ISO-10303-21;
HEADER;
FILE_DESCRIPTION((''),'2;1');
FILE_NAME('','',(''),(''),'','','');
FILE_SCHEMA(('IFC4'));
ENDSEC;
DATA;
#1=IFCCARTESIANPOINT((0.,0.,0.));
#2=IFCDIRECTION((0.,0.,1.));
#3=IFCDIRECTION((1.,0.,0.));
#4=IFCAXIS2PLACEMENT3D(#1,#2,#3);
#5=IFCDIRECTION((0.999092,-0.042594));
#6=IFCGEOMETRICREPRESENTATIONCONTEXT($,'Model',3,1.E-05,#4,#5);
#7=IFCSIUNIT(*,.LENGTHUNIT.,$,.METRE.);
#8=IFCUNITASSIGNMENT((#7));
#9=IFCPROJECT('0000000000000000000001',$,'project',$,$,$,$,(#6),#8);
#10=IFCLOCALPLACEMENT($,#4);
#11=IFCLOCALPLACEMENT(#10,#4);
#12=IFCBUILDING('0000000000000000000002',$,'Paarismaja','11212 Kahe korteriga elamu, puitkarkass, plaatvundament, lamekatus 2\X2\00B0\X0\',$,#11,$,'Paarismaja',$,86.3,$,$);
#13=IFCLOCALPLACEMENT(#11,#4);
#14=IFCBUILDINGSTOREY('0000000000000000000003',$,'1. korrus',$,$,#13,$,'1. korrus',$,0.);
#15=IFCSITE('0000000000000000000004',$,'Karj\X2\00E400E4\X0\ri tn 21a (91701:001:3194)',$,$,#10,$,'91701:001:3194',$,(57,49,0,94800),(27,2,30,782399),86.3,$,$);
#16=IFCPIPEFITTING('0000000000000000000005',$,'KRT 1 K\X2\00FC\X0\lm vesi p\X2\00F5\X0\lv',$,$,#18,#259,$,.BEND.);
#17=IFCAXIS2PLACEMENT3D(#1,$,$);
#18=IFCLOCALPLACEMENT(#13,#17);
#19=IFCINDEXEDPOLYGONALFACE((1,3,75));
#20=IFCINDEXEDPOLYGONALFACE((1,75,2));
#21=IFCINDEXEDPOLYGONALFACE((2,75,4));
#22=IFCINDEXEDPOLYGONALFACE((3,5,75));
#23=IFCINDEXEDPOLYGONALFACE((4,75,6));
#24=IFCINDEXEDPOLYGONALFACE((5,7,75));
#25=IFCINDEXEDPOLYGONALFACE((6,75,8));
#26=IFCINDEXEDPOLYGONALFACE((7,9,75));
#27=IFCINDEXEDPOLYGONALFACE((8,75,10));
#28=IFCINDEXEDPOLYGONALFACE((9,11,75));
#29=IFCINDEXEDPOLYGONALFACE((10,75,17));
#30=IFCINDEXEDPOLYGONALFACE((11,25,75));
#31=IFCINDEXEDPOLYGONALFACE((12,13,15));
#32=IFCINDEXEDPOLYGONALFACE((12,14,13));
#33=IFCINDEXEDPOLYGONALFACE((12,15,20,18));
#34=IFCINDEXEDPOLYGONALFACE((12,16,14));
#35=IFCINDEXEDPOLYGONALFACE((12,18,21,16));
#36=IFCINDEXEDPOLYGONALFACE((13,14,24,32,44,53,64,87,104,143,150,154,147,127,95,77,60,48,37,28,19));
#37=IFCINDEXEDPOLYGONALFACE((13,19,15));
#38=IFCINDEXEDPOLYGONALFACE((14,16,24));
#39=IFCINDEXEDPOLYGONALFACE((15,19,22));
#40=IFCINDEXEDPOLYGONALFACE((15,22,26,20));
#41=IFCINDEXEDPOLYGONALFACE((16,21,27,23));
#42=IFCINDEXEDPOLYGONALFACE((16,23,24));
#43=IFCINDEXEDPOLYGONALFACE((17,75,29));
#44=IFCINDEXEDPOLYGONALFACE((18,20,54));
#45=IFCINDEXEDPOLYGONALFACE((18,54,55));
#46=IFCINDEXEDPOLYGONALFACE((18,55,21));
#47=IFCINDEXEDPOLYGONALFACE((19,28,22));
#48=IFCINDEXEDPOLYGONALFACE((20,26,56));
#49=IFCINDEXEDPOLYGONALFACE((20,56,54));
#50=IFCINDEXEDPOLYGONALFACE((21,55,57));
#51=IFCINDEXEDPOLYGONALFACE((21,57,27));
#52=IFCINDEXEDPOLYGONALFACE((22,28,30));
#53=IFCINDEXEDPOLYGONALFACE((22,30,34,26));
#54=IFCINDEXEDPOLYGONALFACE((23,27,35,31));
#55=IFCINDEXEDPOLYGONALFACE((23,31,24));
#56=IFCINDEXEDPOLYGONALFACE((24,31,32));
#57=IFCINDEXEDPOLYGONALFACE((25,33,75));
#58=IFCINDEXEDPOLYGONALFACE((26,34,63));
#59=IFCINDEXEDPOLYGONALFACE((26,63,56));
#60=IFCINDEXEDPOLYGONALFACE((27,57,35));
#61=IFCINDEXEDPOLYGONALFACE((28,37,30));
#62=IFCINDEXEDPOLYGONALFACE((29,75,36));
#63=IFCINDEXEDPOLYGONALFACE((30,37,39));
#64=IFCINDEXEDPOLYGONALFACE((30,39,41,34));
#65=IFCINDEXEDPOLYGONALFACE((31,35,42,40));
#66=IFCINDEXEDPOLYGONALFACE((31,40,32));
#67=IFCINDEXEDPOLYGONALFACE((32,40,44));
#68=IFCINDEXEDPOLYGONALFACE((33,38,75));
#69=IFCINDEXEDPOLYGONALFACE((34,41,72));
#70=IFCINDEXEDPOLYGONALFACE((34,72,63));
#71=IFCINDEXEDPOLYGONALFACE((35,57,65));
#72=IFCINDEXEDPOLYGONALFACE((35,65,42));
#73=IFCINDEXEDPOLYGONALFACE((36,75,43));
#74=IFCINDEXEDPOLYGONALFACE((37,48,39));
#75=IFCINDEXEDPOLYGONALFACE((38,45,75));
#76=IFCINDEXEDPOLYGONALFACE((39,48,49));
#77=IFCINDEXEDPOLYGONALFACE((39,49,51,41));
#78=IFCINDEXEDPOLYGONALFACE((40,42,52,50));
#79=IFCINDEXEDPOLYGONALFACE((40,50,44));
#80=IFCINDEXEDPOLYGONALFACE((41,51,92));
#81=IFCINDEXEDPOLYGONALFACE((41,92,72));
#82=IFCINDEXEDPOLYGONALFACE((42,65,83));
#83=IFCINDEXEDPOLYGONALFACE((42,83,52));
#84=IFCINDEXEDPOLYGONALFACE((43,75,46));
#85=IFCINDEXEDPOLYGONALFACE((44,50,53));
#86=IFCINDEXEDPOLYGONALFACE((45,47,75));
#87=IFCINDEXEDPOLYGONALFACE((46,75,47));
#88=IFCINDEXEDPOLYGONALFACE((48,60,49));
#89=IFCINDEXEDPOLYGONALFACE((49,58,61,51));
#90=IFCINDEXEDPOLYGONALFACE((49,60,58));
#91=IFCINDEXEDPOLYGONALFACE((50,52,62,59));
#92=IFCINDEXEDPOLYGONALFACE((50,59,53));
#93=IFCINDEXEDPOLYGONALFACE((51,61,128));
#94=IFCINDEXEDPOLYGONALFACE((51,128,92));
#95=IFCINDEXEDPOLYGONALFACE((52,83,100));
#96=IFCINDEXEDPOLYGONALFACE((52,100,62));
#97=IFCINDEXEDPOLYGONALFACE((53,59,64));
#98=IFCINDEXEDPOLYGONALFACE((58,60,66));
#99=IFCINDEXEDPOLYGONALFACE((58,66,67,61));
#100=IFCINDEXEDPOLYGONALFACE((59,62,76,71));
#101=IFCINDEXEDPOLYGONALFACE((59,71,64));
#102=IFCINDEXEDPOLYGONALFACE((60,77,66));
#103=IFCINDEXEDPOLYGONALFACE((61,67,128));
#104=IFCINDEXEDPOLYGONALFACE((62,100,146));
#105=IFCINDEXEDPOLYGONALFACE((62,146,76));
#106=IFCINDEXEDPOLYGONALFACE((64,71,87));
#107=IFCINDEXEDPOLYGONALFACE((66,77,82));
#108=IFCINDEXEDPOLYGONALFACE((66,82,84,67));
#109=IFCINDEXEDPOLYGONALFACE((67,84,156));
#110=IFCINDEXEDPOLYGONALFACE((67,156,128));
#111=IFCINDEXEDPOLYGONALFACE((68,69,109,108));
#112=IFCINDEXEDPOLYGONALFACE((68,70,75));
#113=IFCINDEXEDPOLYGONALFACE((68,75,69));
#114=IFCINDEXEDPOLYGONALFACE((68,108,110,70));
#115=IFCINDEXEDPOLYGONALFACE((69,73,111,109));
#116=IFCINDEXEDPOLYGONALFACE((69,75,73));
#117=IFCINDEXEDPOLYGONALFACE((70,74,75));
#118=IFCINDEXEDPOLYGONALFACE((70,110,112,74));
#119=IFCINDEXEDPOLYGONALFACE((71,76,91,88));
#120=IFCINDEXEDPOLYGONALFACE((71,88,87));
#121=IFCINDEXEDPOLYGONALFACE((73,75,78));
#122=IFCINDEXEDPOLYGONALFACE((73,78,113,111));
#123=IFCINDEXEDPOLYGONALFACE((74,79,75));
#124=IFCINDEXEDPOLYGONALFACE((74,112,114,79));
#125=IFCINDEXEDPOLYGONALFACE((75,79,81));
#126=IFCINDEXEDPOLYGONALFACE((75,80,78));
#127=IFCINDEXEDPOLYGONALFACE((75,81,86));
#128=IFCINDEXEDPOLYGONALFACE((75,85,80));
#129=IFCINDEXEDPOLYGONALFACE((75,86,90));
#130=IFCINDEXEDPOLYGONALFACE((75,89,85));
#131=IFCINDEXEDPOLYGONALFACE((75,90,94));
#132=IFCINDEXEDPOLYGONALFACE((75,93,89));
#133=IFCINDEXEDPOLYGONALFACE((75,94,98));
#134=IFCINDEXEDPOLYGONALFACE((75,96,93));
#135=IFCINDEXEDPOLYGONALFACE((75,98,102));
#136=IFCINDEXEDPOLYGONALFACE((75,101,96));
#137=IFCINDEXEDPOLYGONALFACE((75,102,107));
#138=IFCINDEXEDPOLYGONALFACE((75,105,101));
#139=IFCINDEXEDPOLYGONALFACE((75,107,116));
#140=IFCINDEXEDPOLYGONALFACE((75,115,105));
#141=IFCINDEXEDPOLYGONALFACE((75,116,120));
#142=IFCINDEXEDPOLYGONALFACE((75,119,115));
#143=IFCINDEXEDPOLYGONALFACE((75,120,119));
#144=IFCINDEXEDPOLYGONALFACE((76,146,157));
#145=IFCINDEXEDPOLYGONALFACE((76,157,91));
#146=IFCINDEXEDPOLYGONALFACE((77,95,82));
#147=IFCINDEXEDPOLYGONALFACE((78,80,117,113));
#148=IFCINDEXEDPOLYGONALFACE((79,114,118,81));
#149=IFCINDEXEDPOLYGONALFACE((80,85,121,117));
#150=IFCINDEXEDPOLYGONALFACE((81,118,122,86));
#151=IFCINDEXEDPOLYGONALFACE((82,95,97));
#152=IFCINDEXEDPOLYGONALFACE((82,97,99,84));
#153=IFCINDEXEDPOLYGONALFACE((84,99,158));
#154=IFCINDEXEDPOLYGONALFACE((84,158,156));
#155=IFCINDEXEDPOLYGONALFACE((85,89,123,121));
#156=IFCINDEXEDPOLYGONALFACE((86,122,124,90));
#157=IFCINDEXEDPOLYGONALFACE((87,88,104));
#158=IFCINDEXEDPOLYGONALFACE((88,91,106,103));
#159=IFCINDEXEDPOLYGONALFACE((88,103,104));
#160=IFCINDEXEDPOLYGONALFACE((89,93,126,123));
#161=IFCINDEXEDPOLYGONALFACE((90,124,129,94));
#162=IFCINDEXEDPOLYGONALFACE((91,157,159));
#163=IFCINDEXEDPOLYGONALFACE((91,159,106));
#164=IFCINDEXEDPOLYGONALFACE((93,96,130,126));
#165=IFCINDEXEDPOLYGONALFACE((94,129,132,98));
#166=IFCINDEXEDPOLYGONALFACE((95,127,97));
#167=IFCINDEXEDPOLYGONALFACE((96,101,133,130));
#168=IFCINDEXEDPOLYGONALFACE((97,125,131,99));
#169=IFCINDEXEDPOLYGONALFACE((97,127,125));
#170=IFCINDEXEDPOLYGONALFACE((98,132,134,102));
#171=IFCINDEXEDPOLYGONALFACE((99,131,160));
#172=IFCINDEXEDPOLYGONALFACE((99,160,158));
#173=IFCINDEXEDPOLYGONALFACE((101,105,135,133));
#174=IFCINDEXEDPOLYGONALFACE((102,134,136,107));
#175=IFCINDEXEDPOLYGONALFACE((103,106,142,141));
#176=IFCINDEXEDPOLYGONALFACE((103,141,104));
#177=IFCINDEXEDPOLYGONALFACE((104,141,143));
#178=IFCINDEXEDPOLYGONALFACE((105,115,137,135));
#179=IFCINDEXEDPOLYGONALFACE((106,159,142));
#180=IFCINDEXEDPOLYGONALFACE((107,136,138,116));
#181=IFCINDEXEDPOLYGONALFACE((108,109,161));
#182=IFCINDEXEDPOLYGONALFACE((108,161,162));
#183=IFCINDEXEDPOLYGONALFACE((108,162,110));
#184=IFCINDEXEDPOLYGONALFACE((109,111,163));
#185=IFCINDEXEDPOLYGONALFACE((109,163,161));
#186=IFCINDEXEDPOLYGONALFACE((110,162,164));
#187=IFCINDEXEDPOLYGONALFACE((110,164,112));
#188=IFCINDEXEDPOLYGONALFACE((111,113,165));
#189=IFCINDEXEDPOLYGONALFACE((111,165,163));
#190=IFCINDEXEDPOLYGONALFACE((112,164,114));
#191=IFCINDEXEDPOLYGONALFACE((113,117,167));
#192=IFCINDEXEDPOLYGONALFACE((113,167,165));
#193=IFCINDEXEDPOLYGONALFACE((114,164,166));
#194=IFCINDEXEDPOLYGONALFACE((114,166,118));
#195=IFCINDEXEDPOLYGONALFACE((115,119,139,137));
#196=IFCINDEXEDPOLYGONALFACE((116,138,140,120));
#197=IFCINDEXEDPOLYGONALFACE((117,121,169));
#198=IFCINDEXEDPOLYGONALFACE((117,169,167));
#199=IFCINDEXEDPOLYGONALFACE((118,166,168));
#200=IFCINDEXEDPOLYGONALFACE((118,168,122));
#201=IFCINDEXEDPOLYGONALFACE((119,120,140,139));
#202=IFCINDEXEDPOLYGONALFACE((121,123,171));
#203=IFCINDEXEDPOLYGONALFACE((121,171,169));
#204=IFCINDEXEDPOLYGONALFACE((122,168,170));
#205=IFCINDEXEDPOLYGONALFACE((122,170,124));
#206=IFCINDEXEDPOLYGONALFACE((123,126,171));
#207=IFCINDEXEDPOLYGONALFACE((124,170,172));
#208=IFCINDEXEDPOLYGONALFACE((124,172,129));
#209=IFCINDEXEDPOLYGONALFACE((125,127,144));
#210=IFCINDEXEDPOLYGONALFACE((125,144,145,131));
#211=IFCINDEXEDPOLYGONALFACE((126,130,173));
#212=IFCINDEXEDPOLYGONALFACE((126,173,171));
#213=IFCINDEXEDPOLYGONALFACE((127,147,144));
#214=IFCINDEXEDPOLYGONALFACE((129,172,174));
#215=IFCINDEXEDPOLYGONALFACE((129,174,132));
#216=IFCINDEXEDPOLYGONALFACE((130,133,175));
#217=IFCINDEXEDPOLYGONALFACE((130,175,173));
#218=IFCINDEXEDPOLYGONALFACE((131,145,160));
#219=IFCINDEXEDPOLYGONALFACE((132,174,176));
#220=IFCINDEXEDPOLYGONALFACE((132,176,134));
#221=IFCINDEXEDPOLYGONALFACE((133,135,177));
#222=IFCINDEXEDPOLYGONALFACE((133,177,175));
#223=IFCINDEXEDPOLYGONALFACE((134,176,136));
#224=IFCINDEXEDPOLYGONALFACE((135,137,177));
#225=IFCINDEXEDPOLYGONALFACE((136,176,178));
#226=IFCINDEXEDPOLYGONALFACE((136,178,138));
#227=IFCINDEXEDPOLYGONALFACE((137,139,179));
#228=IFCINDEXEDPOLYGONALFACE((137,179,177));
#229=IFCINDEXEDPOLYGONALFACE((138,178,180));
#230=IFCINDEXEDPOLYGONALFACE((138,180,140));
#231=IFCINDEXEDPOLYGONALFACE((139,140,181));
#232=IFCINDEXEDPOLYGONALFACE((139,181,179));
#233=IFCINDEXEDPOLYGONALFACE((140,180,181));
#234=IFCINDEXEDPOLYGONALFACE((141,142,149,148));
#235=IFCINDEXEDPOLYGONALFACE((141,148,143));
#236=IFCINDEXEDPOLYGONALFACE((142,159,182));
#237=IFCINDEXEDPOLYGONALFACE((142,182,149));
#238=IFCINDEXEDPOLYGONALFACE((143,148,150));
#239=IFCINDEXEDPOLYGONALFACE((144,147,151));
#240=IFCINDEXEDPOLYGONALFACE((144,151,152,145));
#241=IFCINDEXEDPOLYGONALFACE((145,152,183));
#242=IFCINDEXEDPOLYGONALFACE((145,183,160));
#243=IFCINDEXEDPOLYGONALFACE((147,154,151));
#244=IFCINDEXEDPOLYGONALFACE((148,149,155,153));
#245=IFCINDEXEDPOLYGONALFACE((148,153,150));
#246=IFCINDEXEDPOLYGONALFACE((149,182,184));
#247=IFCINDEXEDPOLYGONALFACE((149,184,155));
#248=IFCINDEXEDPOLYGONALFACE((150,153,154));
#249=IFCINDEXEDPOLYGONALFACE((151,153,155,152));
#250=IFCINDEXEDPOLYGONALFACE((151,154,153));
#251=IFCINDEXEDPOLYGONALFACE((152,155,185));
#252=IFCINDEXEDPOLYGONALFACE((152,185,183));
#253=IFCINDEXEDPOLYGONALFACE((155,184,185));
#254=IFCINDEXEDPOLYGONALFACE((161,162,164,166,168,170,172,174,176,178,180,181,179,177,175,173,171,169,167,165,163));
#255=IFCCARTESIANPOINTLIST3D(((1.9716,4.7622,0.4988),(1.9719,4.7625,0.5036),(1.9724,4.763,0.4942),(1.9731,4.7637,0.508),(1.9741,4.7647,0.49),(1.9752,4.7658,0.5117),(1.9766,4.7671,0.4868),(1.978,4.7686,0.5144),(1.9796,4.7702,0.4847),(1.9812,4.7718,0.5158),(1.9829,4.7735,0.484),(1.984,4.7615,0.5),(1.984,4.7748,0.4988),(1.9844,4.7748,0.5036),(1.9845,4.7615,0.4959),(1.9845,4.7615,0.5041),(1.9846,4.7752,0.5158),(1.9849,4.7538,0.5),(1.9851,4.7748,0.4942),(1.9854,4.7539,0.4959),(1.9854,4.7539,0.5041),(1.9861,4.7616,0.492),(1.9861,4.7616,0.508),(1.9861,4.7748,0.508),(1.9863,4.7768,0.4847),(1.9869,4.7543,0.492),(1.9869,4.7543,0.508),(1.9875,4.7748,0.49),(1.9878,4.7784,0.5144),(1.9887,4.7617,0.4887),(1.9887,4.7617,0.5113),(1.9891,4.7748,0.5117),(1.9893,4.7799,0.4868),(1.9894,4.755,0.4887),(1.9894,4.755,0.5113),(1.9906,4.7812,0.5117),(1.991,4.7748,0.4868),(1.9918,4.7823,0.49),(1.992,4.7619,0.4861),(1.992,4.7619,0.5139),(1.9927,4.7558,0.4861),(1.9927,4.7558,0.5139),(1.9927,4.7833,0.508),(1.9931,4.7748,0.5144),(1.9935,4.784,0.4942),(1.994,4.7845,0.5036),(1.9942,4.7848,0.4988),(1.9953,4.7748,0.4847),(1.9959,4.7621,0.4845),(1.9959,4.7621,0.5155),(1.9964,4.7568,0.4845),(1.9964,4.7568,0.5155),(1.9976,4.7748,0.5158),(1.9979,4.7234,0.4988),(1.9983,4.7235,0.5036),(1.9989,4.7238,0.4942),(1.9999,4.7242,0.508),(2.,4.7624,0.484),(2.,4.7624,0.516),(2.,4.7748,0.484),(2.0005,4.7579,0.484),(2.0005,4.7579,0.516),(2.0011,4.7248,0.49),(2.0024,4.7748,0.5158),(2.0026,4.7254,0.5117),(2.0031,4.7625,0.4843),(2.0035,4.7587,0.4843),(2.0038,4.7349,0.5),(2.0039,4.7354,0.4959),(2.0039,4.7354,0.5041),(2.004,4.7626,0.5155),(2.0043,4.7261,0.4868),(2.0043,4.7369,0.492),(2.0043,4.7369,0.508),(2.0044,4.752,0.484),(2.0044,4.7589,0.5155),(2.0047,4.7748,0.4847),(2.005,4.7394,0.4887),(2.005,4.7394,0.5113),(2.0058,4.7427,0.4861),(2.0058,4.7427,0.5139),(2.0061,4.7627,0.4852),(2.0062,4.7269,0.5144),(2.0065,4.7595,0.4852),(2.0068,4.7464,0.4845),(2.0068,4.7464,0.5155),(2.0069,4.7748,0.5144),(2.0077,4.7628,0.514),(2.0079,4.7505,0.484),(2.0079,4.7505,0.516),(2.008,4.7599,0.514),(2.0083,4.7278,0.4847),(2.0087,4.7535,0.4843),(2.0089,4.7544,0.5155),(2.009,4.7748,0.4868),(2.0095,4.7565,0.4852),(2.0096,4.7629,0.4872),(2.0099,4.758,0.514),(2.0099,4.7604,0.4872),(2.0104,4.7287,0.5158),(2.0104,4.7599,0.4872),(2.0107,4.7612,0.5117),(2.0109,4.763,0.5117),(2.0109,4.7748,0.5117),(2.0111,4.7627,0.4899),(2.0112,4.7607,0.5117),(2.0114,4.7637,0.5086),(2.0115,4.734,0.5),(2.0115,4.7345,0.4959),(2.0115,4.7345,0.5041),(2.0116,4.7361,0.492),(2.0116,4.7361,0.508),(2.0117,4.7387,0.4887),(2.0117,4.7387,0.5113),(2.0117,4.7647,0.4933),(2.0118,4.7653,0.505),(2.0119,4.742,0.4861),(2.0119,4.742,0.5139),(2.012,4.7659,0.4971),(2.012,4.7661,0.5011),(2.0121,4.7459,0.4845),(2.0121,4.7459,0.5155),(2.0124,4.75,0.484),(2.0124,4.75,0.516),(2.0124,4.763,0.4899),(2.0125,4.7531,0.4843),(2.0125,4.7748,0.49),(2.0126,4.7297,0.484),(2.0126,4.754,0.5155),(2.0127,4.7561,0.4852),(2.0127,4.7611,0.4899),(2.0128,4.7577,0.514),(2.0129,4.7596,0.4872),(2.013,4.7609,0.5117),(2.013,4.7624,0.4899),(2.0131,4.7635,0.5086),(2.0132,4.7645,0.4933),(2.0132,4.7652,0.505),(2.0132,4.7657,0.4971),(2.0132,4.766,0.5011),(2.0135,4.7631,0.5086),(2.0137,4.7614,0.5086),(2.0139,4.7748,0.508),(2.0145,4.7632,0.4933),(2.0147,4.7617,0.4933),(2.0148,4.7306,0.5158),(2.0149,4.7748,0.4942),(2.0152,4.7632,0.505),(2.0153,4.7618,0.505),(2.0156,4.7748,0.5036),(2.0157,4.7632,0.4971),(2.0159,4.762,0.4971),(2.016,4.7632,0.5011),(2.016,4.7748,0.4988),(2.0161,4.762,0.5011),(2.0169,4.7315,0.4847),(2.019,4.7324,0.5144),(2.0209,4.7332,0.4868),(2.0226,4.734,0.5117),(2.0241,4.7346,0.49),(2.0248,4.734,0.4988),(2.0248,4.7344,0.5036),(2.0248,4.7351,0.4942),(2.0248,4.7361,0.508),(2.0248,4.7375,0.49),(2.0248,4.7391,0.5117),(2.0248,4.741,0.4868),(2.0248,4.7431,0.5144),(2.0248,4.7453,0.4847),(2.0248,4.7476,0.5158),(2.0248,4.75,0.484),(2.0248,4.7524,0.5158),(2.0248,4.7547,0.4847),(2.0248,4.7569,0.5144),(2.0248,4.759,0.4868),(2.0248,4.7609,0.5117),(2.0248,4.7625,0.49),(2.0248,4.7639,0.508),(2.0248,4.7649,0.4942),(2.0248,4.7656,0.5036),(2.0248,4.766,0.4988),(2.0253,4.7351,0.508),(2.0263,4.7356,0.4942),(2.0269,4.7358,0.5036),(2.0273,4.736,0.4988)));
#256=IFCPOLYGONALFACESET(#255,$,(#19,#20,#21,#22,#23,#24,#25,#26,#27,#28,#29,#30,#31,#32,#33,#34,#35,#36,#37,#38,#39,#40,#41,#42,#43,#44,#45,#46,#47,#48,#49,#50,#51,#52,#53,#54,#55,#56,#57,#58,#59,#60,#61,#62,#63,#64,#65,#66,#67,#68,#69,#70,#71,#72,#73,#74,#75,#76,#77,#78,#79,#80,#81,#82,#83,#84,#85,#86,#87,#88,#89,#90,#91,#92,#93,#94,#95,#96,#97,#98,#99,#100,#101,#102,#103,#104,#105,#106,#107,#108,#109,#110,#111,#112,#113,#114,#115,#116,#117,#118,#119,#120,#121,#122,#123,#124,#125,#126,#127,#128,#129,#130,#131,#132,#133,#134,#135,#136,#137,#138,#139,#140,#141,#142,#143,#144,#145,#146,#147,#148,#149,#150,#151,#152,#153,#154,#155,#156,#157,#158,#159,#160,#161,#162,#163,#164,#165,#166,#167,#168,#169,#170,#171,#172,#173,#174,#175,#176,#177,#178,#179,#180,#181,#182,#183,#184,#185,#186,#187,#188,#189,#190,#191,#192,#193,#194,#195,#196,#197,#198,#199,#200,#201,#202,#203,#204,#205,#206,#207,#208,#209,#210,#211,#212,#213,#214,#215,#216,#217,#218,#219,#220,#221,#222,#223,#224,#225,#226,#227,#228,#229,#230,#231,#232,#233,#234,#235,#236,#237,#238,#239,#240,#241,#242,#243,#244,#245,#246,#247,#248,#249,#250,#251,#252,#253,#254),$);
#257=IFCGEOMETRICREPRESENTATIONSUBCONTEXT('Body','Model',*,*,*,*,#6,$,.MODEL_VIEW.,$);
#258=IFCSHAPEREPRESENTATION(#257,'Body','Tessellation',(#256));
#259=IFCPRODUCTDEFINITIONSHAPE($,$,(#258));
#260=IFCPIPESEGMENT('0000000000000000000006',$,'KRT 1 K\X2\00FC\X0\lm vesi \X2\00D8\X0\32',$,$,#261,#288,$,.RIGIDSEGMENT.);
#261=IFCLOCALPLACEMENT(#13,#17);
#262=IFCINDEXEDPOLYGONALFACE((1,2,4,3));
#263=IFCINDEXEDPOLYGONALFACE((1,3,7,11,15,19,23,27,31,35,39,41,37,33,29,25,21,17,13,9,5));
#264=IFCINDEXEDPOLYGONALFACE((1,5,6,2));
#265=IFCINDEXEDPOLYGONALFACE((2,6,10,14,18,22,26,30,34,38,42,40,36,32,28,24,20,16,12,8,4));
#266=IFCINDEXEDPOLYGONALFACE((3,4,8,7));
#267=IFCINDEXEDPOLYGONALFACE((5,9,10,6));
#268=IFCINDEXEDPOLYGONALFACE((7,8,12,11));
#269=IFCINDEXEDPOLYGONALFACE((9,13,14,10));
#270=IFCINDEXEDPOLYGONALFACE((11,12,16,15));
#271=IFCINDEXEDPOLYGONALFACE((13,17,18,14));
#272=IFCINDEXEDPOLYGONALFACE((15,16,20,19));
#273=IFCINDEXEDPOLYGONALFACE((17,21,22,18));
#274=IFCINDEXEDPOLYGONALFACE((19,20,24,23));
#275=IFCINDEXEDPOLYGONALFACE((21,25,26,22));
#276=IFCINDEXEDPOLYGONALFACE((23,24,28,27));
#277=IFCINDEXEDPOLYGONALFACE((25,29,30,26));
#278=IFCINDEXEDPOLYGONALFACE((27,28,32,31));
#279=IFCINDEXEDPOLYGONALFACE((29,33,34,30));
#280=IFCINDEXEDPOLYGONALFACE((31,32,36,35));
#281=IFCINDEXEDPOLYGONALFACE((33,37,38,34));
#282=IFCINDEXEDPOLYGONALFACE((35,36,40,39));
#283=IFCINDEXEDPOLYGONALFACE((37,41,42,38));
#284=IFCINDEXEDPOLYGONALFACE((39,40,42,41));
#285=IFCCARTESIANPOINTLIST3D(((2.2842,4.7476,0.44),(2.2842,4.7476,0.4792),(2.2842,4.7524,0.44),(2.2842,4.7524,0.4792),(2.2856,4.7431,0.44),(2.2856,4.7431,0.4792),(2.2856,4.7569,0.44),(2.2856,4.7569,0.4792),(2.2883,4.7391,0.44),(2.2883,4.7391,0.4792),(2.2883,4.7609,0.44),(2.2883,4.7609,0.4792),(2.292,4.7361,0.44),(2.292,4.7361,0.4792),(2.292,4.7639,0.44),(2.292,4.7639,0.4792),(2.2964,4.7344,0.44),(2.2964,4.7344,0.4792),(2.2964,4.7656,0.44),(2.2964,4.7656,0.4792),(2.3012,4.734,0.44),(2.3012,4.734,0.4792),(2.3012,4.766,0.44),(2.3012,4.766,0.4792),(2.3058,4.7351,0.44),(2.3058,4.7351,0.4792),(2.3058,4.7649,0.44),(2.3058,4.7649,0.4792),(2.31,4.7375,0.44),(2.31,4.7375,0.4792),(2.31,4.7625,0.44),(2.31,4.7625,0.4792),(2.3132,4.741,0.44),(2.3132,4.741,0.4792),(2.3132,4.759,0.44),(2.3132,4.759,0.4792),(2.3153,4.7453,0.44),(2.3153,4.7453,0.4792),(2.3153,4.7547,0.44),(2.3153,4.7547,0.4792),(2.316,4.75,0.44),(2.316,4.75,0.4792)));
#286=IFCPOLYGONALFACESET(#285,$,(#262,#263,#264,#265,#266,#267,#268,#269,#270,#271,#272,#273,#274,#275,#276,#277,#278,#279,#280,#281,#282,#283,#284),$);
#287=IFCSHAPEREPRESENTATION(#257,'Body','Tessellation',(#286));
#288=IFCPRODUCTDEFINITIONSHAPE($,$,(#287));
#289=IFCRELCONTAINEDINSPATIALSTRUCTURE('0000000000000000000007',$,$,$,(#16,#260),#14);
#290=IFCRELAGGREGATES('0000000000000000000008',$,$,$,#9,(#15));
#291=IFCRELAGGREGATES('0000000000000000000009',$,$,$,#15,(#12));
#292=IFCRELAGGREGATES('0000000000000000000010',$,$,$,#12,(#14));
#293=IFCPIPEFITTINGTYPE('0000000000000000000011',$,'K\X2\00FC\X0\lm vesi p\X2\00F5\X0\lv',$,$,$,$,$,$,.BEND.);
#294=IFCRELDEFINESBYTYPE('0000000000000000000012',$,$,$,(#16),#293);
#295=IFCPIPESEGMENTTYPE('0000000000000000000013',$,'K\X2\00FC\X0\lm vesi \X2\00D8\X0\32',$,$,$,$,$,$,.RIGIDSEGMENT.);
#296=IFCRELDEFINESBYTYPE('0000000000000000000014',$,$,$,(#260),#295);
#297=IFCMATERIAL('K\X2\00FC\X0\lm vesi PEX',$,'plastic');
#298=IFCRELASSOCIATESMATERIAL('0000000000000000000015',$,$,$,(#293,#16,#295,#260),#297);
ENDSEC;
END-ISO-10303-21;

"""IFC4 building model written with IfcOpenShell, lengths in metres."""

from ifc_helpers import new_model, entity, si_unit, direction, frame, origin_with_axes, place, context, subcontext, project, spatial, circle, extrude, material, type_object, element, save


model = new_model("IFC4")

# Units and contexts
model_context = context("Model", 3, precision=1e-05, world=origin_with_axes(), true_north=direction((0.999092, -0.042594)))
body_context = subcontext(model_context, "Body", "Model", "MODEL_VIEW")
ifc_project = project(units=[si_unit("LENGTHUNIT", "METRE")], contexts=[model_context])

# Site, building, storey
site_placement = place(None, origin_with_axes())
site = spatial("IfcSite", under=ifc_project, at=site_placement, Name="Karjääri tn 21a (91701:001:3194)", LongName="91701:001:3194", RefLatitude=(57, 49, 0, 94800), RefLongitude=(27, 2, 30, 782399), RefElevation=86.3)
building_placement = place(site_placement, origin_with_axes())
building = spatial("IfcBuilding", under=site, at=building_placement, Name="Paarismaja", Description="11212 Kahe korteriga elamu, puitkarkass, plaatvundament, lamekatus 2°", LongName="Paarismaja", ElevationOfRefHeight=86.3)
storey_placement = place(building_placement, origin_with_axes())
storey = spatial("IfcBuildingStorey", under=building, at=storey_placement, Name="1. korrus", LongName="1. korrus", Elevation=0.0)

# Pipe fitting
ifc_material_1 = material(Name="Külm vesi PEX", Category="plastic")
pipe_fitting_type_1 = type_object("IfcPipeFittingType", Name="Külm vesi põlv", PredefinedType="BEND", material=ifc_material_1)
pipe_fitting_1_placement = place(storey_placement, frame((2.0, 4.75, 0.5), z_axis=(0.0, 0.0, 1.0), x_axis=(1.0, 0.0, 0.0)))
element("IfcPipeFitting", 1, at=pipe_fitting_1_placement, inside=storey, type_object=pipe_fitting_type_1, material=ifc_material_1, Name="KRT 1 Külm vesi põlv", PredefinedType="BEND", context=body_context, shape_type="AdvancedSweptSolid", body=[
    entity("IfcSweptDiskSolid", entity("IfcIndexedPolyCurve", entity("IfcCartesianPointList3D", [[0.0248, 0.0, 0.0], [0.0124, 0.0, 0.0], [0.0079, 0.0005, 0.0], [0.0044, 0.002, 0.0], [0.002, 0.0044, 0.0], [0.0005, 0.0079, 0.0], [0.0, 0.0124, 0.0], [0.0, 0.0248, 0.0]]), None, False), 0.016),
])

# Pipe segment
pipe_segment_type_1 = type_object("IfcPipeSegmentType", Name="Külm vesi Ø32", PredefinedType="RIGIDSEGMENT", material=ifc_material_1)
pipe_segment_1_placement = place(storey_placement, frame((2.3, 4.75, 0.44), z_axis=(0.0, 0.0, 1.0), x_axis=(1.0, 0.0, 0.0)))
element("IfcPipeSegment", 2, at=pipe_segment_1_placement, inside=storey, type_object=pipe_segment_type_1, material=ifc_material_1, Name="KRT 1 Külm vesi Ø32", PredefinedType="RIGIDSEGMENT", context=body_context, shape_type="SweptSolid", body=[
    extrude(circle(Radius=0.016), origin_with_axes(), (0.0, 0.0, 1.0), 0.0392),
])

save(model, "model.ifc")
